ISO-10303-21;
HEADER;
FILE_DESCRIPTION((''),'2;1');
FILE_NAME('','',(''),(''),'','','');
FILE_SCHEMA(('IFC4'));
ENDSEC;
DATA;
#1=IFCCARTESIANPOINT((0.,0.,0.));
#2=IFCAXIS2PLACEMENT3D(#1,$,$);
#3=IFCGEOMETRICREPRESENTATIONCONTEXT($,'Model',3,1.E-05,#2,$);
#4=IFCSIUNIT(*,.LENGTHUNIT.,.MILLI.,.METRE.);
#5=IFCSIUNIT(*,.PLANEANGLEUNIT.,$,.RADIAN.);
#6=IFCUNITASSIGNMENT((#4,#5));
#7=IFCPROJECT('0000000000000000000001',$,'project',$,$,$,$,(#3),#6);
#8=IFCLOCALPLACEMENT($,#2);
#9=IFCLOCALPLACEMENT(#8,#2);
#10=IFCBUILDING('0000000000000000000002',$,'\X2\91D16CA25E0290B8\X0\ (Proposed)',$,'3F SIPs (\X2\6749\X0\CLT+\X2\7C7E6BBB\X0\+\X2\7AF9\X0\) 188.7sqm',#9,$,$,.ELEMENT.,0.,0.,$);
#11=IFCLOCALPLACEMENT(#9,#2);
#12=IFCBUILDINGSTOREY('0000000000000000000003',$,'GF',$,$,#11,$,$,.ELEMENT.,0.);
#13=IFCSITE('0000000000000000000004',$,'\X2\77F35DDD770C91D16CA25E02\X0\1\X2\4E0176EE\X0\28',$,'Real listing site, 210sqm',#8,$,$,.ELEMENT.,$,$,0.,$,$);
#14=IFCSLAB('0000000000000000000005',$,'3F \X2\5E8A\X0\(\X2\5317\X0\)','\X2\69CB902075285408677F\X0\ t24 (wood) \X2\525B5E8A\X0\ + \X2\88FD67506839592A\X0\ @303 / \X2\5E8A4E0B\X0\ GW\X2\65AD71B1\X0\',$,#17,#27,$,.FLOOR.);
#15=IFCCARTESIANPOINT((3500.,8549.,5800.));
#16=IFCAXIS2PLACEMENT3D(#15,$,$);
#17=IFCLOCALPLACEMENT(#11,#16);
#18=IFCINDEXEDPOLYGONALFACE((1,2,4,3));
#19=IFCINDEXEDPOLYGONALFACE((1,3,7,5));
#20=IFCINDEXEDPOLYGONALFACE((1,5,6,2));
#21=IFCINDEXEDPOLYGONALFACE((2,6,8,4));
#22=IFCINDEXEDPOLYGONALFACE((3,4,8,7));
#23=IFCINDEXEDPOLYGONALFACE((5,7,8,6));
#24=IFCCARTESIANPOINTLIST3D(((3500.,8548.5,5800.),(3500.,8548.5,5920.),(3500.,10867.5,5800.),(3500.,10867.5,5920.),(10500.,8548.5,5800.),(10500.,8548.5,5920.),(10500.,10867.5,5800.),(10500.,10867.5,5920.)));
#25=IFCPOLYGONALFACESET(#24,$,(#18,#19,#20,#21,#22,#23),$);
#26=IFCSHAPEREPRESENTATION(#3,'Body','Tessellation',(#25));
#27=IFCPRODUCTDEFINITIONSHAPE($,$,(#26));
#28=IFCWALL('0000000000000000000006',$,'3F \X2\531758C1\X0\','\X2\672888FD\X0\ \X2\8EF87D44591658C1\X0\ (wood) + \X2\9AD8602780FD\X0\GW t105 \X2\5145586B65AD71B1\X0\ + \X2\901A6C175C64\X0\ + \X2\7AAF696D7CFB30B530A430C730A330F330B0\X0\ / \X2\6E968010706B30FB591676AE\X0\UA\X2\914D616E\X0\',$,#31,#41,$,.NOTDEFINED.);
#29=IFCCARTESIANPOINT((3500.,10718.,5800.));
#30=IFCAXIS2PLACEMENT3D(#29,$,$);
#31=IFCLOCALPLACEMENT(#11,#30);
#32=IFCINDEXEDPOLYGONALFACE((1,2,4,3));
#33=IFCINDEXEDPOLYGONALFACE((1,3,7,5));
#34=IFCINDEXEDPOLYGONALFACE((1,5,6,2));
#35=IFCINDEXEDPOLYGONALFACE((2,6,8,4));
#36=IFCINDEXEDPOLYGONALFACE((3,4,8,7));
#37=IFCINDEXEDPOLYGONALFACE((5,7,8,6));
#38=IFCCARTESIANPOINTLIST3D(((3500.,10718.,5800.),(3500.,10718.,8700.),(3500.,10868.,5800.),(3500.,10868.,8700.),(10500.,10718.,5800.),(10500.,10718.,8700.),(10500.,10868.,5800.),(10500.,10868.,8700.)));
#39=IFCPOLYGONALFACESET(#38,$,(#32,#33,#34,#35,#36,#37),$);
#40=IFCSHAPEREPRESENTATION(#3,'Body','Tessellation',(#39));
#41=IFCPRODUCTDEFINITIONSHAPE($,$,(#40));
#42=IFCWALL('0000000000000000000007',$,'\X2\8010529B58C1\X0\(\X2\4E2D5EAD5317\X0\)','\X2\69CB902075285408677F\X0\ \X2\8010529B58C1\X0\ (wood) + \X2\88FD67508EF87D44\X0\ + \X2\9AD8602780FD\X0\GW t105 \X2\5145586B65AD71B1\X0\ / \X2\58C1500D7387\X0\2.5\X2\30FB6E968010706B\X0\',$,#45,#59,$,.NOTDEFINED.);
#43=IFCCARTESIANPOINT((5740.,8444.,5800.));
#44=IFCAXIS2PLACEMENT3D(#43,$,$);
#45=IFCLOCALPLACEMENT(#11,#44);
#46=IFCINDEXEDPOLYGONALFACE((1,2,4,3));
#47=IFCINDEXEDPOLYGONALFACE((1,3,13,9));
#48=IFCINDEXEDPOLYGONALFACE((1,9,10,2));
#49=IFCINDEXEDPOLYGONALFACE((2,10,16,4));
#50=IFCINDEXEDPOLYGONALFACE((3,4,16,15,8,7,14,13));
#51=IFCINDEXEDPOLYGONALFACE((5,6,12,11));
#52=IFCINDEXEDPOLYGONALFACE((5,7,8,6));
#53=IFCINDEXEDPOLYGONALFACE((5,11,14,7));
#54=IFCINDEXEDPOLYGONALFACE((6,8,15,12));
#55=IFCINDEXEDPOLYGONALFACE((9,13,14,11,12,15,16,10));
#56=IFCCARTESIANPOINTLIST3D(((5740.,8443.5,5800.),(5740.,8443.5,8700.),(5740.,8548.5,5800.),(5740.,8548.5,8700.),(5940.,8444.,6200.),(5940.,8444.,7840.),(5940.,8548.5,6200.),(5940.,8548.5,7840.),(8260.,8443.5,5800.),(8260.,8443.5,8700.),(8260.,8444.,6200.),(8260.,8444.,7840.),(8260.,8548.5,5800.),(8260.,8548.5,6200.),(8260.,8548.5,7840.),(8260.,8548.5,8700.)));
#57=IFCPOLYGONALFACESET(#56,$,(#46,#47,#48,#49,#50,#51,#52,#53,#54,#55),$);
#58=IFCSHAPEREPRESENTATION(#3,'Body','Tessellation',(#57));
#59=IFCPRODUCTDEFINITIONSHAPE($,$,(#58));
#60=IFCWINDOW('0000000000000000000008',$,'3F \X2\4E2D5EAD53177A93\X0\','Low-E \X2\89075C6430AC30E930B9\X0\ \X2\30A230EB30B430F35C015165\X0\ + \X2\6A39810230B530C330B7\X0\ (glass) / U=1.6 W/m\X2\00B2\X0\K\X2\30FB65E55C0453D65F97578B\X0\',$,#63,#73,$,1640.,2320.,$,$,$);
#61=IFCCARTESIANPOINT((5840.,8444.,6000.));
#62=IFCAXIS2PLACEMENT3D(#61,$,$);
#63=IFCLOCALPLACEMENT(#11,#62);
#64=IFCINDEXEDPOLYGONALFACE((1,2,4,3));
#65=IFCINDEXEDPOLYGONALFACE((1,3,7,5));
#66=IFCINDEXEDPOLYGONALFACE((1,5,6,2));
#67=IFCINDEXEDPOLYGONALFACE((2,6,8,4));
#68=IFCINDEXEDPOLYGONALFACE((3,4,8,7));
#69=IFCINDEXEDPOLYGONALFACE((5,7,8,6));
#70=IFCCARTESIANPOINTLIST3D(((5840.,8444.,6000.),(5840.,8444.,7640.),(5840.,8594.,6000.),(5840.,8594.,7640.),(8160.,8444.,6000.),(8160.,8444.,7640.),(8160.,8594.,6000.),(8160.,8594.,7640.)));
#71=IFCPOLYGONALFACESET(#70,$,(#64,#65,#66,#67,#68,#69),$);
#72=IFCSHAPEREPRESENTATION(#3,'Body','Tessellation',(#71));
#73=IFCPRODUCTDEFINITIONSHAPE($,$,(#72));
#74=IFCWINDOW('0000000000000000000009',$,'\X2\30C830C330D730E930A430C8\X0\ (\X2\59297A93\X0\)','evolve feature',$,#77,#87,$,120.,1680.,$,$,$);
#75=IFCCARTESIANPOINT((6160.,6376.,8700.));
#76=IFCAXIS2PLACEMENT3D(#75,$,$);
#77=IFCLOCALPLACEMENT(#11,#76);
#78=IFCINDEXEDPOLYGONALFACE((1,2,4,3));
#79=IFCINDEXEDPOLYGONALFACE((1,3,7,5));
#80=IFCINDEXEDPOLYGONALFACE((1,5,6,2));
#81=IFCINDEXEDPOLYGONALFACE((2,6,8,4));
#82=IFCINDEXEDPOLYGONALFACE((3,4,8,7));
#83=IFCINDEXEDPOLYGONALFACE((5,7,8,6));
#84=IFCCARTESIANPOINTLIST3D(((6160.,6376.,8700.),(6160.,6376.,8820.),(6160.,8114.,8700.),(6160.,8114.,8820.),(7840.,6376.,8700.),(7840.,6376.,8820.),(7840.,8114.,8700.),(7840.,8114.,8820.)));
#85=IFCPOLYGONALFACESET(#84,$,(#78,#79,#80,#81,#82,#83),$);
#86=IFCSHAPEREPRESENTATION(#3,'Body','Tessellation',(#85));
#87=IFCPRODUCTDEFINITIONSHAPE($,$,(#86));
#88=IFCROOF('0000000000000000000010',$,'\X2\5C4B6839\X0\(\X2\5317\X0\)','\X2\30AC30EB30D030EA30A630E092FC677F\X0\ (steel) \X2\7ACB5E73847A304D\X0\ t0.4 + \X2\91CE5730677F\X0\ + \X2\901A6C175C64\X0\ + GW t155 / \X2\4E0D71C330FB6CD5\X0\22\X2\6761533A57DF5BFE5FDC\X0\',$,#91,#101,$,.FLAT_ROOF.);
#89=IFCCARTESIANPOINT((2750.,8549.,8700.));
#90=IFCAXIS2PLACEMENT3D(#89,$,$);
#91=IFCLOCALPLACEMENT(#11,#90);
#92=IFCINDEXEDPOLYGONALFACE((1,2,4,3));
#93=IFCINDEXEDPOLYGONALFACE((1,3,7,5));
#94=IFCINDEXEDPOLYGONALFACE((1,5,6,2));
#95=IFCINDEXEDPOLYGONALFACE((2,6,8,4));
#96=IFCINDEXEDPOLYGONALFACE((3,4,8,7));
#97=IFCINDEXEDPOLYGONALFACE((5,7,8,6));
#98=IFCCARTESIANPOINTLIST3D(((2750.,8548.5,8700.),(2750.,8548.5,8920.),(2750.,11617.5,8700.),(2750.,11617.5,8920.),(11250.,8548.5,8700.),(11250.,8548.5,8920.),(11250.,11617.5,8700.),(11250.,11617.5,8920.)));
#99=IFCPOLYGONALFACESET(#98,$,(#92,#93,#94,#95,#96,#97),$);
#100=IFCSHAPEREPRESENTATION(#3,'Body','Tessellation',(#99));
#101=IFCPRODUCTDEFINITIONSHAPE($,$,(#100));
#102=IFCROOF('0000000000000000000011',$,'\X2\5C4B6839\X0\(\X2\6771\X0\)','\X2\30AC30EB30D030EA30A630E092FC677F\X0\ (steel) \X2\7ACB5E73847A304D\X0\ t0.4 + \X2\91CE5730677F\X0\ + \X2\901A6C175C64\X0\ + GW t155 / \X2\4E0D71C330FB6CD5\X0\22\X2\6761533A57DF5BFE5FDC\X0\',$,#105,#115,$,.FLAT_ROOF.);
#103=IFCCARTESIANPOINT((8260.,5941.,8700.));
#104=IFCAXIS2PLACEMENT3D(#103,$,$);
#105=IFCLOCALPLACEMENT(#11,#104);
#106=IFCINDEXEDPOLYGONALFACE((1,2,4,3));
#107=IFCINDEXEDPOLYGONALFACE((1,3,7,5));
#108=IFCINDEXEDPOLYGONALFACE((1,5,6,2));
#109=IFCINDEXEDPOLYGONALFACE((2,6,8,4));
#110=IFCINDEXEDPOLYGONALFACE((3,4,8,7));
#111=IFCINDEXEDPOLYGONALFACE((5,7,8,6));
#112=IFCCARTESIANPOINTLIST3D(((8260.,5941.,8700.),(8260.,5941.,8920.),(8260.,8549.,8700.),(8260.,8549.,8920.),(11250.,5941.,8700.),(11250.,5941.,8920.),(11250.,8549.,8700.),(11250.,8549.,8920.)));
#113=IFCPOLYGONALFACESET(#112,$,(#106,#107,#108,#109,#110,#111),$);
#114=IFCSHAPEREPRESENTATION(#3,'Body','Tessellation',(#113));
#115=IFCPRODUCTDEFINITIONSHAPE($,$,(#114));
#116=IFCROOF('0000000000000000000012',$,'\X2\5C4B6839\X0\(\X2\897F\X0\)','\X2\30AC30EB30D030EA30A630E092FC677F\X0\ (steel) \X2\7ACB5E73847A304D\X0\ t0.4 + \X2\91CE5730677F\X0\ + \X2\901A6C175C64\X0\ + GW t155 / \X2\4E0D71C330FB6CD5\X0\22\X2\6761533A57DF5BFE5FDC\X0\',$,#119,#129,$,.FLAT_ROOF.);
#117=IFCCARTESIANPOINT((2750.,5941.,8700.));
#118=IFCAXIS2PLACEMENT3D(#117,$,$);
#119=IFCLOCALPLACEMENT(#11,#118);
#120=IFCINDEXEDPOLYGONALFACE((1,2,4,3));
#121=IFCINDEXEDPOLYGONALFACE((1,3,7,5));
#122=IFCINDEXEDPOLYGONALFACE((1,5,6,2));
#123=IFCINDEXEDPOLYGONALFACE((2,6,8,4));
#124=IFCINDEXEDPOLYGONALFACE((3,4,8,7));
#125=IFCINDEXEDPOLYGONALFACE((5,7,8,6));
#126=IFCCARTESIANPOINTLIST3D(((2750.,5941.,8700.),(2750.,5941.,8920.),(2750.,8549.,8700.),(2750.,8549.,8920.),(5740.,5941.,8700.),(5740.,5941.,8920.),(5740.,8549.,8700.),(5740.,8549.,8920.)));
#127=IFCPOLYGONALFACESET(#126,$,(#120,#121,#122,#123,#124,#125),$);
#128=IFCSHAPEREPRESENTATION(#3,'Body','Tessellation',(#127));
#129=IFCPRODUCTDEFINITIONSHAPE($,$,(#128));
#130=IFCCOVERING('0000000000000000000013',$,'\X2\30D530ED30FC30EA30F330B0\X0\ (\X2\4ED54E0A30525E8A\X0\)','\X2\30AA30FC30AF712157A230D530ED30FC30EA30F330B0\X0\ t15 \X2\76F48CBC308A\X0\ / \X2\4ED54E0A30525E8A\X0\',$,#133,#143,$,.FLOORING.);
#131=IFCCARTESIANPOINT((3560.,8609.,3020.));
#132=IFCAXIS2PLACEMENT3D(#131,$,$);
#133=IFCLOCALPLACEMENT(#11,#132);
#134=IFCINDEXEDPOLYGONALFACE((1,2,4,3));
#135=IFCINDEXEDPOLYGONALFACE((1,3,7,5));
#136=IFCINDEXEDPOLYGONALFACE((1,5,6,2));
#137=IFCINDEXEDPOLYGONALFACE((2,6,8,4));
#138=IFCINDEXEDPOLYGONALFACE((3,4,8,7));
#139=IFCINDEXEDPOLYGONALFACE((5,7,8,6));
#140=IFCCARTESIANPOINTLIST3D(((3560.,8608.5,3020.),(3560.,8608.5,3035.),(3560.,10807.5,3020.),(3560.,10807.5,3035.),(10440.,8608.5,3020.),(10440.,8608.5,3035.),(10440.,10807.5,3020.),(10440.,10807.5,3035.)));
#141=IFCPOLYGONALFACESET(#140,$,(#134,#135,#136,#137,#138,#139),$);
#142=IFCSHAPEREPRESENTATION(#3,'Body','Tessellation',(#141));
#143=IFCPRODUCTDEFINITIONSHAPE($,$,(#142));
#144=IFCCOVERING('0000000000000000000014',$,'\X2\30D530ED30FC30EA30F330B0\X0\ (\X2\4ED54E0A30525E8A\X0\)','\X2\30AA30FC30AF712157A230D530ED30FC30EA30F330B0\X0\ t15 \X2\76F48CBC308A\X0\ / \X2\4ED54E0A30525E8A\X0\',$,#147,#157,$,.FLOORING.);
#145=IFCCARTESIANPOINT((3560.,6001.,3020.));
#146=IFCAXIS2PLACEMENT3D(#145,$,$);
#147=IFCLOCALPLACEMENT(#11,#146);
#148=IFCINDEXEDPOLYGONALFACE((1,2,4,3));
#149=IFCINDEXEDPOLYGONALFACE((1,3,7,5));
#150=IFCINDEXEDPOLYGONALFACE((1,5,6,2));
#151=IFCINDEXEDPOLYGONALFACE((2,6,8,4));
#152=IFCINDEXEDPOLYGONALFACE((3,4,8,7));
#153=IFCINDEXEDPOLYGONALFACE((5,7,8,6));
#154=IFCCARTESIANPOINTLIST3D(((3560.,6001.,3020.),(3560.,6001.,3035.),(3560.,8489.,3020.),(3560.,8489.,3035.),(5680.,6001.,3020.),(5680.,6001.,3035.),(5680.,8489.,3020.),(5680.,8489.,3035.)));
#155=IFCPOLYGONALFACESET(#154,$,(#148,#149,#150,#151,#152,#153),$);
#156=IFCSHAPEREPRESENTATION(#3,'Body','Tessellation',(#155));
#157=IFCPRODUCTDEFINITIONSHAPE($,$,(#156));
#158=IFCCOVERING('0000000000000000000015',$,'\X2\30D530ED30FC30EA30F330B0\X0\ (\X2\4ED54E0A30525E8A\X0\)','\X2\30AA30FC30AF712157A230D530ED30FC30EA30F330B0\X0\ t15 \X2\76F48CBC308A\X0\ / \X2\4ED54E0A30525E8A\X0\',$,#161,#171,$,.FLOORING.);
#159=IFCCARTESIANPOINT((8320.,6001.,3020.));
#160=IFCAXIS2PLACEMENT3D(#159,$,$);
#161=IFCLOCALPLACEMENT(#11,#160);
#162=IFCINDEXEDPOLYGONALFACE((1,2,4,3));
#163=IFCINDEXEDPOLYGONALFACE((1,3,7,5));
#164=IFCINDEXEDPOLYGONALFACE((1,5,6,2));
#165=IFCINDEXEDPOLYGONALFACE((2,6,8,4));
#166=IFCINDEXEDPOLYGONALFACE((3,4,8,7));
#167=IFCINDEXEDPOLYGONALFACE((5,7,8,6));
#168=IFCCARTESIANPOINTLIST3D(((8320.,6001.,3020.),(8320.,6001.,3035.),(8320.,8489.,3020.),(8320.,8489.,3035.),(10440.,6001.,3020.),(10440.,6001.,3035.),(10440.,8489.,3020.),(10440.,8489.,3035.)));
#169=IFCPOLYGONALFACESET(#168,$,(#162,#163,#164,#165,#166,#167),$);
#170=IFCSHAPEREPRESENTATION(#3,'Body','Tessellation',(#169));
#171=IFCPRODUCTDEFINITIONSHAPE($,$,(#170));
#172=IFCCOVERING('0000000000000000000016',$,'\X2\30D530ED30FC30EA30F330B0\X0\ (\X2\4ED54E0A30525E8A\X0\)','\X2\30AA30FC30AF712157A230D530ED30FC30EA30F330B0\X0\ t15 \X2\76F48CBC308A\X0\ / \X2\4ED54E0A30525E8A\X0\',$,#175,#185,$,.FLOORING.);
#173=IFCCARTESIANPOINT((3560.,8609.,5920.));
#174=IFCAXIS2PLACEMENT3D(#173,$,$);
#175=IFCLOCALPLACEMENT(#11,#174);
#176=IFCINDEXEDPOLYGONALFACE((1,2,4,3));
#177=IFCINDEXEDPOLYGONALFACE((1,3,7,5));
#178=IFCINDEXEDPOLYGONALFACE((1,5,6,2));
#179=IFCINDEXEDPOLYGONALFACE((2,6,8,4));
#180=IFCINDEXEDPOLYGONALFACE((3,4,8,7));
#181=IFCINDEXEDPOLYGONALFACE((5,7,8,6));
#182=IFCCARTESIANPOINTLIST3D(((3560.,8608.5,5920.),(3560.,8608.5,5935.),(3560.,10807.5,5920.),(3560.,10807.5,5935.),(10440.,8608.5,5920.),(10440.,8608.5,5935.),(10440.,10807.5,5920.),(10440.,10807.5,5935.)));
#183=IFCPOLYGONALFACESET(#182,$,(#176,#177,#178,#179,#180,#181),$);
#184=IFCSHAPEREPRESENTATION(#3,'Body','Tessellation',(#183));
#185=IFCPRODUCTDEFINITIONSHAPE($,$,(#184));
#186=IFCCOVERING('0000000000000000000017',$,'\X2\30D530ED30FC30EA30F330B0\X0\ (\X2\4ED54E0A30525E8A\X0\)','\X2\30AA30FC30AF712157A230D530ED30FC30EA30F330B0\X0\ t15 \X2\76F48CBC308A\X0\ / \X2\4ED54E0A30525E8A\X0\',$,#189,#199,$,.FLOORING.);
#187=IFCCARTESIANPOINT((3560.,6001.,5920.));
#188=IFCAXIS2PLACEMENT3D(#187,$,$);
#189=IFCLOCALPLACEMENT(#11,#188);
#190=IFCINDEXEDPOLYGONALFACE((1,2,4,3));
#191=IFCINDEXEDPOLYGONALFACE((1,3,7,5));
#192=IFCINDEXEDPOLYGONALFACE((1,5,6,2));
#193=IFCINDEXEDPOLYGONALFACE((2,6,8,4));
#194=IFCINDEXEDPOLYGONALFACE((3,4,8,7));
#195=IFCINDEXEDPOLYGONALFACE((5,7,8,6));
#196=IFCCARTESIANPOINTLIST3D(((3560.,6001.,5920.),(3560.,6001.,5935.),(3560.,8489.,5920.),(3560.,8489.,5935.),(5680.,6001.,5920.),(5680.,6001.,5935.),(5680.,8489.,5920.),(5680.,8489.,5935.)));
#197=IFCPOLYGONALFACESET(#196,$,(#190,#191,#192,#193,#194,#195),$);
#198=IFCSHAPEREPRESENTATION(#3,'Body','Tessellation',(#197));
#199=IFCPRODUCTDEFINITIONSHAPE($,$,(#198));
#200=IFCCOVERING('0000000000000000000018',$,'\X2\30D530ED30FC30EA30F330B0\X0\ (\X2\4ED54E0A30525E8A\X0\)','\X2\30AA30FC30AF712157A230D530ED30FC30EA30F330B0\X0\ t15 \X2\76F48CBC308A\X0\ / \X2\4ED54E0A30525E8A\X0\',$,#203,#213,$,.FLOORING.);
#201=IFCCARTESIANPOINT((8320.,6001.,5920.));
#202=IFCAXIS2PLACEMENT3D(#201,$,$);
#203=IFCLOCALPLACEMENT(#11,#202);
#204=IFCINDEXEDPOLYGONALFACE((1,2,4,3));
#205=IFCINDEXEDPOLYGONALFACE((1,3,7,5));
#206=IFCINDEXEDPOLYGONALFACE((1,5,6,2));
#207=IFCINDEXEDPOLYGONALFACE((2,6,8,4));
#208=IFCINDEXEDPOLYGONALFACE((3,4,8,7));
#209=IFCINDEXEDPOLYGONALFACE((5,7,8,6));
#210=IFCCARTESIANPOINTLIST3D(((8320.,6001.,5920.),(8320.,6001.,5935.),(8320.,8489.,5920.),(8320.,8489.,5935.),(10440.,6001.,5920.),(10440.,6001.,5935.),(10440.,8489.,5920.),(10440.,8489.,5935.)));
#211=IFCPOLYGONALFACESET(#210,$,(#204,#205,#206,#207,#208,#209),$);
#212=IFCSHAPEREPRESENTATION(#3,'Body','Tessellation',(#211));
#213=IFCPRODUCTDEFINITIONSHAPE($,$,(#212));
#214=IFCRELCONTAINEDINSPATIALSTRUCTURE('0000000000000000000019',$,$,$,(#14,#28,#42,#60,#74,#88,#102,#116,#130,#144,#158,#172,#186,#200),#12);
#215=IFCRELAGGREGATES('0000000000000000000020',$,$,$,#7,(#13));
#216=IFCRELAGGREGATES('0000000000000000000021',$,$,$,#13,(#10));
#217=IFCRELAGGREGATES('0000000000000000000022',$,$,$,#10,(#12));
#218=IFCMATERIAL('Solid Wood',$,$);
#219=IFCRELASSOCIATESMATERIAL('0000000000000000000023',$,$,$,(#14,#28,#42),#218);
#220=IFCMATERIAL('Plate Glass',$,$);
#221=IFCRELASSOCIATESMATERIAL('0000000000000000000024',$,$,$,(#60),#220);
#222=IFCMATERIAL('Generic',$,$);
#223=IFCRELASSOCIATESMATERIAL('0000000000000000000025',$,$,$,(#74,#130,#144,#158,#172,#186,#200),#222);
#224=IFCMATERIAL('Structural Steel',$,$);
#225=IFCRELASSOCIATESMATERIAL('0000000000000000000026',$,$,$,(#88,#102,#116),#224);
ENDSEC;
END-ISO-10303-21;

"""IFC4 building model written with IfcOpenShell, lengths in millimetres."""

from ifc_helpers import new_model, si_unit, frame, frame_2d, origin, place, context, project, spatial, rectangle, extrude, material, element, fill, save


model = new_model("IFC4")

# Units and contexts
model_context = context("Model", 3, precision=1e-05, world=origin())
ifc_project = project(units=[si_unit("LENGTHUNIT", "METRE", prefix="MILLI"), si_unit("PLANEANGLEUNIT", "RADIAN")], contexts=[model_context])

# Site, building, storey
site_placement = place(None, origin())
site = spatial("IfcSite", under=ifc_project, at=site_placement, Name="石川県金沢市1丁目28", ObjectType="Real listing site, 210sqm", CompositionType="ELEMENT", RefElevation=0.0)
building_placement = place(site_placement, origin())
building = spatial("IfcBuilding", under=site, at=building_placement, Name="金沢市邸 (Proposed)", ObjectType="3F SIPs (杉CLT+籾殻+竹) 188.7sqm", CompositionType="ELEMENT", ElevationOfRefHeight=0.0, ElevationOfTerrain=0.0)
storey_placement = place(building_placement, origin())
storey = spatial("IfcBuildingStorey", under=building, at=storey_placement, Name="GF", CompositionType="ELEMENT", Elevation=0.0)

# Slab
ifc_material_1 = material(Name="Solid Wood")
slab_placement = place(storey_placement, frame((3500.0, 8549.0, 5800.0)))
element("IfcSlab", 1, at=slab_placement, inside=storey, material=ifc_material_1, Name="3F 床(北)", Description="構造用合板 t24 (wood) 剛床 + 製材根太 @303 / 床下 GW断熱", PredefinedType="FLOOR", context=model_context, shape_type="SweptSolid", body=[
    extrude(rectangle(XDim=7000.0, YDim=2319.0, at=frame_2d((3500.0, 1159.0))), frame((3500.0, 8549.0, 5800.0)), (0.0, 0.0, 1.0), 120.0),
])

# Wall
wall_1_placement = place(storey_placement, frame((3500.0, 10718.0, 5800.0)))
element("IfcWall", 2, at=wall_1_placement, inside=storey, material=ifc_material_1, Name="3F 北壁", Description="木製 軸組外壁 (wood) + 高性能GW t105 充填断熱 + 通気層 + 窯業系サイディング / 準耐火・外皮UA配慮", PredefinedType="NOTDEFINED", context=model_context, shape_type="SweptSolid", body=[
    extrude(rectangle(XDim=7000.0, YDim=150.0, at=frame_2d((3500.0, 75.0))), frame((3500.0, 10718.0, 5800.0)), (0.0, 0.0, 1.0), 2900.0),
])

# Wall, opening, window
wall_2_placement = place(storey_placement, frame((5740.0, 8444.0, 5800.0)))
wall_2 = element("IfcWall", 3, at=wall_2_placement, inside=storey, material=ifc_material_1, Name="耐力壁(中庭北)", Description="構造用合板 耐力壁 (wood) + 製材軸組 + 高性能GW t105 充填断熱 / 壁倍率2.5・準耐火", PredefinedType="NOTDEFINED", context=model_context, shape_type="SweptSolid", body=[
    extrude(rectangle(XDim=2520.0, YDim=105.0, at=frame_2d((1260.0, 52.0))), frame((5740.0, 8444.0, 5800.0)), (0.0, 0.0, 1.0), 2900.0),
])
opening_placement = place(storey_placement, frame((5840.0, 8444.0, 6000.0)))
opening = element("IfcOpeningElement", 4, at=opening_placement, cuts=wall_2, PredefinedType="NOTDEFINED", context=model_context, shape_type="SweptSolid", body=[
    extrude(rectangle(XDim=2320.0, YDim=150.0, at=frame_2d((1160.0, 75.0))), frame((5840.0, 8444.0, 6000.0)), (0.0, 0.0, 1.0), 1640.0),
])
ifc_material_2 = material(Name="Plate Glass")
window_1_placement = place(storey_placement, frame((5840.0, 8444.0, 6000.0)))
window_1 = element("IfcWindow", 5, at=window_1_placement, inside=storey, material=ifc_material_2, Name="3F 中庭北窓", Description="Low-E 複層ガラス アルゴン封入 + 樹脂サッシ (glass) / U=1.6 W/m²K・日射取得型", OverallHeight=1640.0, OverallWidth=2320.0, context=model_context, shape_type="SweptSolid", body=[
    extrude(rectangle(XDim=2320.0, YDim=150.0, at=frame_2d((1160.0, 75.0))), frame((5840.0, 8444.0, 6000.0)), (0.0, 0.0, 1.0), 1640.0),
])
fill(opening, window_1)

# Window
ifc_material_3 = material(Name="Generic")
window_2_placement = place(storey_placement, frame((6160.0, 6376.0, 8700.0)))
element("IfcWindow", 6, at=window_2_placement, inside=storey, material=ifc_material_3, Name="トップライト (天窓)", Description="evolve feature", OverallHeight=120.0, OverallWidth=1680.0, context=model_context, shape_type="SweptSolid", body=[
    extrude(rectangle(XDim=1680.0, YDim=1738.0, at=frame_2d((840.0, 869.0))), frame((6160.0, 6376.0, 8700.0)), (0.0, 0.0, 1.0), 120.0),
])

# Roofs
ifc_material_4 = material(Name="Structural Steel")
roof_1_placement = place(storey_placement, frame((2750.0, 8549.0, 8700.0)))
element("IfcRoof", 7, at=roof_1_placement, inside=storey, material=ifc_material_4, Name="屋根(北)", Description="ガルバリウム鋼板 (steel) 立平葺き t0.4 + 野地板 + 通気層 + GW t155 / 不燃・法22条区域対応", PredefinedType="FLAT_ROOF", context=model_context, shape_type="SweptSolid", body=[
    extrude(rectangle(XDim=8500.0, YDim=3069.0, at=frame_2d((4250.0, 1534.0))), frame((2750.0, 8549.0, 8700.0)), (0.0, 0.0, 1.0), 220.0),
])
roof_2_placement = place(storey_placement, frame((8260.0, 5941.0, 8700.0)))
element("IfcRoof", 8, at=roof_2_placement, inside=storey, material=ifc_material_4, Name="屋根(東)", Description="ガルバリウム鋼板 (steel) 立平葺き t0.4 + 野地板 + 通気層 + GW t155 / 不燃・法22条区域対応", PredefinedType="FLAT_ROOF", context=model_context, shape_type="SweptSolid", body=[
    extrude(rectangle(XDim=2990.0, YDim=2608.0, at=frame_2d((1495.0, 1304.0))), frame((8260.0, 5941.0, 8700.0)), (0.0, 0.0, 1.0), 220.0),
])
roof_3_placement = place(storey_placement, frame((2750.0, 5941.0, 8700.0)))
element("IfcRoof", 9, at=roof_3_placement, inside=storey, material=ifc_material_4, Name="屋根(西)", Description="ガルバリウム鋼板 (steel) 立平葺き t0.4 + 野地板 + 通気層 + GW t155 / 不燃・法22条区域対応", PredefinedType="FLAT_ROOF", context=model_context, shape_type="SweptSolid", body=[
    extrude(rectangle(XDim=2990.0, YDim=2608.0, at=frame_2d((1495.0, 1304.0))), frame((2750.0, 5941.0, 8700.0)), (0.0, 0.0, 1.0), 220.0),
])

# Coverings
covering_1_placement = place(storey_placement, frame((3560.0, 8609.0, 3020.0)))
element("IfcCovering", 10, at=covering_1_placement, inside=storey, material=ifc_material_3, Name="フローリング (仕上げ床)", Description="オーク無垢フローリング t15 直貼り / 仕上げ床", PredefinedType="FLOORING", context=model_context, shape_type="SweptSolid", body=[
    extrude(rectangle(XDim=6880.0, YDim=2199.0, at=frame_2d((3440.0, 1099.0))), frame((3560.0, 8609.0, 3020.0)), (0.0, 0.0, 1.0), 15.0),
])
covering_2_placement = place(storey_placement, frame((3560.0, 6001.0, 3020.0)))
element("IfcCovering", 11, at=covering_2_placement, inside=storey, material=ifc_material_3, Name="フローリング (仕上げ床)", Description="オーク無垢フローリング t15 直貼り / 仕上げ床", PredefinedType="FLOORING", context=model_context, shape_type="SweptSolid", body=[
    extrude(rectangle(XDim=2120.0, YDim=2488.0, at=frame_2d((1060.0, 1244.0))), frame((3560.0, 6001.0, 3020.0)), (0.0, 0.0, 1.0), 15.0),
])
covering_3_placement = place(storey_placement, frame((8320.0, 6001.0, 3020.0)))
element("IfcCovering", 12, at=covering_3_placement, inside=storey, material=ifc_material_3, Name="フローリング (仕上げ床)", Description="オーク無垢フローリング t15 直貼り / 仕上げ床", PredefinedType="FLOORING", context=model_context, shape_type="SweptSolid", body=[
    extrude(rectangle(XDim=2120.0, YDim=2488.0, at=frame_2d((1060.0, 1244.0))), frame((8320.0, 6001.0, 3020.0)), (0.0, 0.0, 1.0), 15.0),
])
covering_4_placement = place(storey_placement, frame((3560.0, 8609.0, 5920.0)))
element("IfcCovering", 13, at=covering_4_placement, inside=storey, material=ifc_material_3, Name="フローリング (仕上げ床)", Description="オーク無垢フローリング t15 直貼り / 仕上げ床", PredefinedType="FLOORING", context=model_context, shape_type="SweptSolid", body=[
    extrude(rectangle(XDim=6880.0, YDim=2199.0, at=frame_2d((3440.0, 1099.0))), frame((3560.0, 8609.0, 5920.0)), (0.0, 0.0, 1.0), 15.0),
])
covering_5_placement = place(storey_placement, frame((3560.0, 6001.0, 5920.0)))
element("IfcCovering", 14, at=covering_5_placement, inside=storey, material=ifc_material_3, Name="フローリング (仕上げ床)", Description="オーク無垢フローリング t15 直貼り / 仕上げ床", PredefinedType="FLOORING", context=model_context, shape_type="SweptSolid", body=[
    extrude(rectangle(XDim=2120.0, YDim=2488.0, at=frame_2d((1060.0, 1244.0))), frame((3560.0, 6001.0, 5920.0)), (0.0, 0.0, 1.0), 15.0),
])
covering_6_placement = place(storey_placement, frame((8320.0, 6001.0, 5920.0)))
element("IfcCovering", 15, at=covering_6_placement, inside=storey, material=ifc_material_3, Name="フローリング (仕上げ床)", Description="オーク無垢フローリング t15 直貼り / 仕上げ床", PredefinedType="FLOORING", context=model_context, shape_type="SweptSolid", body=[
    extrude(rectangle(XDim=2120.0, YDim=2488.0, at=frame_2d((1060.0, 1244.0))), frame((8320.0, 6001.0, 5920.0)), (0.0, 0.0, 1.0), 15.0),
])

save(model, "model.ifc")
